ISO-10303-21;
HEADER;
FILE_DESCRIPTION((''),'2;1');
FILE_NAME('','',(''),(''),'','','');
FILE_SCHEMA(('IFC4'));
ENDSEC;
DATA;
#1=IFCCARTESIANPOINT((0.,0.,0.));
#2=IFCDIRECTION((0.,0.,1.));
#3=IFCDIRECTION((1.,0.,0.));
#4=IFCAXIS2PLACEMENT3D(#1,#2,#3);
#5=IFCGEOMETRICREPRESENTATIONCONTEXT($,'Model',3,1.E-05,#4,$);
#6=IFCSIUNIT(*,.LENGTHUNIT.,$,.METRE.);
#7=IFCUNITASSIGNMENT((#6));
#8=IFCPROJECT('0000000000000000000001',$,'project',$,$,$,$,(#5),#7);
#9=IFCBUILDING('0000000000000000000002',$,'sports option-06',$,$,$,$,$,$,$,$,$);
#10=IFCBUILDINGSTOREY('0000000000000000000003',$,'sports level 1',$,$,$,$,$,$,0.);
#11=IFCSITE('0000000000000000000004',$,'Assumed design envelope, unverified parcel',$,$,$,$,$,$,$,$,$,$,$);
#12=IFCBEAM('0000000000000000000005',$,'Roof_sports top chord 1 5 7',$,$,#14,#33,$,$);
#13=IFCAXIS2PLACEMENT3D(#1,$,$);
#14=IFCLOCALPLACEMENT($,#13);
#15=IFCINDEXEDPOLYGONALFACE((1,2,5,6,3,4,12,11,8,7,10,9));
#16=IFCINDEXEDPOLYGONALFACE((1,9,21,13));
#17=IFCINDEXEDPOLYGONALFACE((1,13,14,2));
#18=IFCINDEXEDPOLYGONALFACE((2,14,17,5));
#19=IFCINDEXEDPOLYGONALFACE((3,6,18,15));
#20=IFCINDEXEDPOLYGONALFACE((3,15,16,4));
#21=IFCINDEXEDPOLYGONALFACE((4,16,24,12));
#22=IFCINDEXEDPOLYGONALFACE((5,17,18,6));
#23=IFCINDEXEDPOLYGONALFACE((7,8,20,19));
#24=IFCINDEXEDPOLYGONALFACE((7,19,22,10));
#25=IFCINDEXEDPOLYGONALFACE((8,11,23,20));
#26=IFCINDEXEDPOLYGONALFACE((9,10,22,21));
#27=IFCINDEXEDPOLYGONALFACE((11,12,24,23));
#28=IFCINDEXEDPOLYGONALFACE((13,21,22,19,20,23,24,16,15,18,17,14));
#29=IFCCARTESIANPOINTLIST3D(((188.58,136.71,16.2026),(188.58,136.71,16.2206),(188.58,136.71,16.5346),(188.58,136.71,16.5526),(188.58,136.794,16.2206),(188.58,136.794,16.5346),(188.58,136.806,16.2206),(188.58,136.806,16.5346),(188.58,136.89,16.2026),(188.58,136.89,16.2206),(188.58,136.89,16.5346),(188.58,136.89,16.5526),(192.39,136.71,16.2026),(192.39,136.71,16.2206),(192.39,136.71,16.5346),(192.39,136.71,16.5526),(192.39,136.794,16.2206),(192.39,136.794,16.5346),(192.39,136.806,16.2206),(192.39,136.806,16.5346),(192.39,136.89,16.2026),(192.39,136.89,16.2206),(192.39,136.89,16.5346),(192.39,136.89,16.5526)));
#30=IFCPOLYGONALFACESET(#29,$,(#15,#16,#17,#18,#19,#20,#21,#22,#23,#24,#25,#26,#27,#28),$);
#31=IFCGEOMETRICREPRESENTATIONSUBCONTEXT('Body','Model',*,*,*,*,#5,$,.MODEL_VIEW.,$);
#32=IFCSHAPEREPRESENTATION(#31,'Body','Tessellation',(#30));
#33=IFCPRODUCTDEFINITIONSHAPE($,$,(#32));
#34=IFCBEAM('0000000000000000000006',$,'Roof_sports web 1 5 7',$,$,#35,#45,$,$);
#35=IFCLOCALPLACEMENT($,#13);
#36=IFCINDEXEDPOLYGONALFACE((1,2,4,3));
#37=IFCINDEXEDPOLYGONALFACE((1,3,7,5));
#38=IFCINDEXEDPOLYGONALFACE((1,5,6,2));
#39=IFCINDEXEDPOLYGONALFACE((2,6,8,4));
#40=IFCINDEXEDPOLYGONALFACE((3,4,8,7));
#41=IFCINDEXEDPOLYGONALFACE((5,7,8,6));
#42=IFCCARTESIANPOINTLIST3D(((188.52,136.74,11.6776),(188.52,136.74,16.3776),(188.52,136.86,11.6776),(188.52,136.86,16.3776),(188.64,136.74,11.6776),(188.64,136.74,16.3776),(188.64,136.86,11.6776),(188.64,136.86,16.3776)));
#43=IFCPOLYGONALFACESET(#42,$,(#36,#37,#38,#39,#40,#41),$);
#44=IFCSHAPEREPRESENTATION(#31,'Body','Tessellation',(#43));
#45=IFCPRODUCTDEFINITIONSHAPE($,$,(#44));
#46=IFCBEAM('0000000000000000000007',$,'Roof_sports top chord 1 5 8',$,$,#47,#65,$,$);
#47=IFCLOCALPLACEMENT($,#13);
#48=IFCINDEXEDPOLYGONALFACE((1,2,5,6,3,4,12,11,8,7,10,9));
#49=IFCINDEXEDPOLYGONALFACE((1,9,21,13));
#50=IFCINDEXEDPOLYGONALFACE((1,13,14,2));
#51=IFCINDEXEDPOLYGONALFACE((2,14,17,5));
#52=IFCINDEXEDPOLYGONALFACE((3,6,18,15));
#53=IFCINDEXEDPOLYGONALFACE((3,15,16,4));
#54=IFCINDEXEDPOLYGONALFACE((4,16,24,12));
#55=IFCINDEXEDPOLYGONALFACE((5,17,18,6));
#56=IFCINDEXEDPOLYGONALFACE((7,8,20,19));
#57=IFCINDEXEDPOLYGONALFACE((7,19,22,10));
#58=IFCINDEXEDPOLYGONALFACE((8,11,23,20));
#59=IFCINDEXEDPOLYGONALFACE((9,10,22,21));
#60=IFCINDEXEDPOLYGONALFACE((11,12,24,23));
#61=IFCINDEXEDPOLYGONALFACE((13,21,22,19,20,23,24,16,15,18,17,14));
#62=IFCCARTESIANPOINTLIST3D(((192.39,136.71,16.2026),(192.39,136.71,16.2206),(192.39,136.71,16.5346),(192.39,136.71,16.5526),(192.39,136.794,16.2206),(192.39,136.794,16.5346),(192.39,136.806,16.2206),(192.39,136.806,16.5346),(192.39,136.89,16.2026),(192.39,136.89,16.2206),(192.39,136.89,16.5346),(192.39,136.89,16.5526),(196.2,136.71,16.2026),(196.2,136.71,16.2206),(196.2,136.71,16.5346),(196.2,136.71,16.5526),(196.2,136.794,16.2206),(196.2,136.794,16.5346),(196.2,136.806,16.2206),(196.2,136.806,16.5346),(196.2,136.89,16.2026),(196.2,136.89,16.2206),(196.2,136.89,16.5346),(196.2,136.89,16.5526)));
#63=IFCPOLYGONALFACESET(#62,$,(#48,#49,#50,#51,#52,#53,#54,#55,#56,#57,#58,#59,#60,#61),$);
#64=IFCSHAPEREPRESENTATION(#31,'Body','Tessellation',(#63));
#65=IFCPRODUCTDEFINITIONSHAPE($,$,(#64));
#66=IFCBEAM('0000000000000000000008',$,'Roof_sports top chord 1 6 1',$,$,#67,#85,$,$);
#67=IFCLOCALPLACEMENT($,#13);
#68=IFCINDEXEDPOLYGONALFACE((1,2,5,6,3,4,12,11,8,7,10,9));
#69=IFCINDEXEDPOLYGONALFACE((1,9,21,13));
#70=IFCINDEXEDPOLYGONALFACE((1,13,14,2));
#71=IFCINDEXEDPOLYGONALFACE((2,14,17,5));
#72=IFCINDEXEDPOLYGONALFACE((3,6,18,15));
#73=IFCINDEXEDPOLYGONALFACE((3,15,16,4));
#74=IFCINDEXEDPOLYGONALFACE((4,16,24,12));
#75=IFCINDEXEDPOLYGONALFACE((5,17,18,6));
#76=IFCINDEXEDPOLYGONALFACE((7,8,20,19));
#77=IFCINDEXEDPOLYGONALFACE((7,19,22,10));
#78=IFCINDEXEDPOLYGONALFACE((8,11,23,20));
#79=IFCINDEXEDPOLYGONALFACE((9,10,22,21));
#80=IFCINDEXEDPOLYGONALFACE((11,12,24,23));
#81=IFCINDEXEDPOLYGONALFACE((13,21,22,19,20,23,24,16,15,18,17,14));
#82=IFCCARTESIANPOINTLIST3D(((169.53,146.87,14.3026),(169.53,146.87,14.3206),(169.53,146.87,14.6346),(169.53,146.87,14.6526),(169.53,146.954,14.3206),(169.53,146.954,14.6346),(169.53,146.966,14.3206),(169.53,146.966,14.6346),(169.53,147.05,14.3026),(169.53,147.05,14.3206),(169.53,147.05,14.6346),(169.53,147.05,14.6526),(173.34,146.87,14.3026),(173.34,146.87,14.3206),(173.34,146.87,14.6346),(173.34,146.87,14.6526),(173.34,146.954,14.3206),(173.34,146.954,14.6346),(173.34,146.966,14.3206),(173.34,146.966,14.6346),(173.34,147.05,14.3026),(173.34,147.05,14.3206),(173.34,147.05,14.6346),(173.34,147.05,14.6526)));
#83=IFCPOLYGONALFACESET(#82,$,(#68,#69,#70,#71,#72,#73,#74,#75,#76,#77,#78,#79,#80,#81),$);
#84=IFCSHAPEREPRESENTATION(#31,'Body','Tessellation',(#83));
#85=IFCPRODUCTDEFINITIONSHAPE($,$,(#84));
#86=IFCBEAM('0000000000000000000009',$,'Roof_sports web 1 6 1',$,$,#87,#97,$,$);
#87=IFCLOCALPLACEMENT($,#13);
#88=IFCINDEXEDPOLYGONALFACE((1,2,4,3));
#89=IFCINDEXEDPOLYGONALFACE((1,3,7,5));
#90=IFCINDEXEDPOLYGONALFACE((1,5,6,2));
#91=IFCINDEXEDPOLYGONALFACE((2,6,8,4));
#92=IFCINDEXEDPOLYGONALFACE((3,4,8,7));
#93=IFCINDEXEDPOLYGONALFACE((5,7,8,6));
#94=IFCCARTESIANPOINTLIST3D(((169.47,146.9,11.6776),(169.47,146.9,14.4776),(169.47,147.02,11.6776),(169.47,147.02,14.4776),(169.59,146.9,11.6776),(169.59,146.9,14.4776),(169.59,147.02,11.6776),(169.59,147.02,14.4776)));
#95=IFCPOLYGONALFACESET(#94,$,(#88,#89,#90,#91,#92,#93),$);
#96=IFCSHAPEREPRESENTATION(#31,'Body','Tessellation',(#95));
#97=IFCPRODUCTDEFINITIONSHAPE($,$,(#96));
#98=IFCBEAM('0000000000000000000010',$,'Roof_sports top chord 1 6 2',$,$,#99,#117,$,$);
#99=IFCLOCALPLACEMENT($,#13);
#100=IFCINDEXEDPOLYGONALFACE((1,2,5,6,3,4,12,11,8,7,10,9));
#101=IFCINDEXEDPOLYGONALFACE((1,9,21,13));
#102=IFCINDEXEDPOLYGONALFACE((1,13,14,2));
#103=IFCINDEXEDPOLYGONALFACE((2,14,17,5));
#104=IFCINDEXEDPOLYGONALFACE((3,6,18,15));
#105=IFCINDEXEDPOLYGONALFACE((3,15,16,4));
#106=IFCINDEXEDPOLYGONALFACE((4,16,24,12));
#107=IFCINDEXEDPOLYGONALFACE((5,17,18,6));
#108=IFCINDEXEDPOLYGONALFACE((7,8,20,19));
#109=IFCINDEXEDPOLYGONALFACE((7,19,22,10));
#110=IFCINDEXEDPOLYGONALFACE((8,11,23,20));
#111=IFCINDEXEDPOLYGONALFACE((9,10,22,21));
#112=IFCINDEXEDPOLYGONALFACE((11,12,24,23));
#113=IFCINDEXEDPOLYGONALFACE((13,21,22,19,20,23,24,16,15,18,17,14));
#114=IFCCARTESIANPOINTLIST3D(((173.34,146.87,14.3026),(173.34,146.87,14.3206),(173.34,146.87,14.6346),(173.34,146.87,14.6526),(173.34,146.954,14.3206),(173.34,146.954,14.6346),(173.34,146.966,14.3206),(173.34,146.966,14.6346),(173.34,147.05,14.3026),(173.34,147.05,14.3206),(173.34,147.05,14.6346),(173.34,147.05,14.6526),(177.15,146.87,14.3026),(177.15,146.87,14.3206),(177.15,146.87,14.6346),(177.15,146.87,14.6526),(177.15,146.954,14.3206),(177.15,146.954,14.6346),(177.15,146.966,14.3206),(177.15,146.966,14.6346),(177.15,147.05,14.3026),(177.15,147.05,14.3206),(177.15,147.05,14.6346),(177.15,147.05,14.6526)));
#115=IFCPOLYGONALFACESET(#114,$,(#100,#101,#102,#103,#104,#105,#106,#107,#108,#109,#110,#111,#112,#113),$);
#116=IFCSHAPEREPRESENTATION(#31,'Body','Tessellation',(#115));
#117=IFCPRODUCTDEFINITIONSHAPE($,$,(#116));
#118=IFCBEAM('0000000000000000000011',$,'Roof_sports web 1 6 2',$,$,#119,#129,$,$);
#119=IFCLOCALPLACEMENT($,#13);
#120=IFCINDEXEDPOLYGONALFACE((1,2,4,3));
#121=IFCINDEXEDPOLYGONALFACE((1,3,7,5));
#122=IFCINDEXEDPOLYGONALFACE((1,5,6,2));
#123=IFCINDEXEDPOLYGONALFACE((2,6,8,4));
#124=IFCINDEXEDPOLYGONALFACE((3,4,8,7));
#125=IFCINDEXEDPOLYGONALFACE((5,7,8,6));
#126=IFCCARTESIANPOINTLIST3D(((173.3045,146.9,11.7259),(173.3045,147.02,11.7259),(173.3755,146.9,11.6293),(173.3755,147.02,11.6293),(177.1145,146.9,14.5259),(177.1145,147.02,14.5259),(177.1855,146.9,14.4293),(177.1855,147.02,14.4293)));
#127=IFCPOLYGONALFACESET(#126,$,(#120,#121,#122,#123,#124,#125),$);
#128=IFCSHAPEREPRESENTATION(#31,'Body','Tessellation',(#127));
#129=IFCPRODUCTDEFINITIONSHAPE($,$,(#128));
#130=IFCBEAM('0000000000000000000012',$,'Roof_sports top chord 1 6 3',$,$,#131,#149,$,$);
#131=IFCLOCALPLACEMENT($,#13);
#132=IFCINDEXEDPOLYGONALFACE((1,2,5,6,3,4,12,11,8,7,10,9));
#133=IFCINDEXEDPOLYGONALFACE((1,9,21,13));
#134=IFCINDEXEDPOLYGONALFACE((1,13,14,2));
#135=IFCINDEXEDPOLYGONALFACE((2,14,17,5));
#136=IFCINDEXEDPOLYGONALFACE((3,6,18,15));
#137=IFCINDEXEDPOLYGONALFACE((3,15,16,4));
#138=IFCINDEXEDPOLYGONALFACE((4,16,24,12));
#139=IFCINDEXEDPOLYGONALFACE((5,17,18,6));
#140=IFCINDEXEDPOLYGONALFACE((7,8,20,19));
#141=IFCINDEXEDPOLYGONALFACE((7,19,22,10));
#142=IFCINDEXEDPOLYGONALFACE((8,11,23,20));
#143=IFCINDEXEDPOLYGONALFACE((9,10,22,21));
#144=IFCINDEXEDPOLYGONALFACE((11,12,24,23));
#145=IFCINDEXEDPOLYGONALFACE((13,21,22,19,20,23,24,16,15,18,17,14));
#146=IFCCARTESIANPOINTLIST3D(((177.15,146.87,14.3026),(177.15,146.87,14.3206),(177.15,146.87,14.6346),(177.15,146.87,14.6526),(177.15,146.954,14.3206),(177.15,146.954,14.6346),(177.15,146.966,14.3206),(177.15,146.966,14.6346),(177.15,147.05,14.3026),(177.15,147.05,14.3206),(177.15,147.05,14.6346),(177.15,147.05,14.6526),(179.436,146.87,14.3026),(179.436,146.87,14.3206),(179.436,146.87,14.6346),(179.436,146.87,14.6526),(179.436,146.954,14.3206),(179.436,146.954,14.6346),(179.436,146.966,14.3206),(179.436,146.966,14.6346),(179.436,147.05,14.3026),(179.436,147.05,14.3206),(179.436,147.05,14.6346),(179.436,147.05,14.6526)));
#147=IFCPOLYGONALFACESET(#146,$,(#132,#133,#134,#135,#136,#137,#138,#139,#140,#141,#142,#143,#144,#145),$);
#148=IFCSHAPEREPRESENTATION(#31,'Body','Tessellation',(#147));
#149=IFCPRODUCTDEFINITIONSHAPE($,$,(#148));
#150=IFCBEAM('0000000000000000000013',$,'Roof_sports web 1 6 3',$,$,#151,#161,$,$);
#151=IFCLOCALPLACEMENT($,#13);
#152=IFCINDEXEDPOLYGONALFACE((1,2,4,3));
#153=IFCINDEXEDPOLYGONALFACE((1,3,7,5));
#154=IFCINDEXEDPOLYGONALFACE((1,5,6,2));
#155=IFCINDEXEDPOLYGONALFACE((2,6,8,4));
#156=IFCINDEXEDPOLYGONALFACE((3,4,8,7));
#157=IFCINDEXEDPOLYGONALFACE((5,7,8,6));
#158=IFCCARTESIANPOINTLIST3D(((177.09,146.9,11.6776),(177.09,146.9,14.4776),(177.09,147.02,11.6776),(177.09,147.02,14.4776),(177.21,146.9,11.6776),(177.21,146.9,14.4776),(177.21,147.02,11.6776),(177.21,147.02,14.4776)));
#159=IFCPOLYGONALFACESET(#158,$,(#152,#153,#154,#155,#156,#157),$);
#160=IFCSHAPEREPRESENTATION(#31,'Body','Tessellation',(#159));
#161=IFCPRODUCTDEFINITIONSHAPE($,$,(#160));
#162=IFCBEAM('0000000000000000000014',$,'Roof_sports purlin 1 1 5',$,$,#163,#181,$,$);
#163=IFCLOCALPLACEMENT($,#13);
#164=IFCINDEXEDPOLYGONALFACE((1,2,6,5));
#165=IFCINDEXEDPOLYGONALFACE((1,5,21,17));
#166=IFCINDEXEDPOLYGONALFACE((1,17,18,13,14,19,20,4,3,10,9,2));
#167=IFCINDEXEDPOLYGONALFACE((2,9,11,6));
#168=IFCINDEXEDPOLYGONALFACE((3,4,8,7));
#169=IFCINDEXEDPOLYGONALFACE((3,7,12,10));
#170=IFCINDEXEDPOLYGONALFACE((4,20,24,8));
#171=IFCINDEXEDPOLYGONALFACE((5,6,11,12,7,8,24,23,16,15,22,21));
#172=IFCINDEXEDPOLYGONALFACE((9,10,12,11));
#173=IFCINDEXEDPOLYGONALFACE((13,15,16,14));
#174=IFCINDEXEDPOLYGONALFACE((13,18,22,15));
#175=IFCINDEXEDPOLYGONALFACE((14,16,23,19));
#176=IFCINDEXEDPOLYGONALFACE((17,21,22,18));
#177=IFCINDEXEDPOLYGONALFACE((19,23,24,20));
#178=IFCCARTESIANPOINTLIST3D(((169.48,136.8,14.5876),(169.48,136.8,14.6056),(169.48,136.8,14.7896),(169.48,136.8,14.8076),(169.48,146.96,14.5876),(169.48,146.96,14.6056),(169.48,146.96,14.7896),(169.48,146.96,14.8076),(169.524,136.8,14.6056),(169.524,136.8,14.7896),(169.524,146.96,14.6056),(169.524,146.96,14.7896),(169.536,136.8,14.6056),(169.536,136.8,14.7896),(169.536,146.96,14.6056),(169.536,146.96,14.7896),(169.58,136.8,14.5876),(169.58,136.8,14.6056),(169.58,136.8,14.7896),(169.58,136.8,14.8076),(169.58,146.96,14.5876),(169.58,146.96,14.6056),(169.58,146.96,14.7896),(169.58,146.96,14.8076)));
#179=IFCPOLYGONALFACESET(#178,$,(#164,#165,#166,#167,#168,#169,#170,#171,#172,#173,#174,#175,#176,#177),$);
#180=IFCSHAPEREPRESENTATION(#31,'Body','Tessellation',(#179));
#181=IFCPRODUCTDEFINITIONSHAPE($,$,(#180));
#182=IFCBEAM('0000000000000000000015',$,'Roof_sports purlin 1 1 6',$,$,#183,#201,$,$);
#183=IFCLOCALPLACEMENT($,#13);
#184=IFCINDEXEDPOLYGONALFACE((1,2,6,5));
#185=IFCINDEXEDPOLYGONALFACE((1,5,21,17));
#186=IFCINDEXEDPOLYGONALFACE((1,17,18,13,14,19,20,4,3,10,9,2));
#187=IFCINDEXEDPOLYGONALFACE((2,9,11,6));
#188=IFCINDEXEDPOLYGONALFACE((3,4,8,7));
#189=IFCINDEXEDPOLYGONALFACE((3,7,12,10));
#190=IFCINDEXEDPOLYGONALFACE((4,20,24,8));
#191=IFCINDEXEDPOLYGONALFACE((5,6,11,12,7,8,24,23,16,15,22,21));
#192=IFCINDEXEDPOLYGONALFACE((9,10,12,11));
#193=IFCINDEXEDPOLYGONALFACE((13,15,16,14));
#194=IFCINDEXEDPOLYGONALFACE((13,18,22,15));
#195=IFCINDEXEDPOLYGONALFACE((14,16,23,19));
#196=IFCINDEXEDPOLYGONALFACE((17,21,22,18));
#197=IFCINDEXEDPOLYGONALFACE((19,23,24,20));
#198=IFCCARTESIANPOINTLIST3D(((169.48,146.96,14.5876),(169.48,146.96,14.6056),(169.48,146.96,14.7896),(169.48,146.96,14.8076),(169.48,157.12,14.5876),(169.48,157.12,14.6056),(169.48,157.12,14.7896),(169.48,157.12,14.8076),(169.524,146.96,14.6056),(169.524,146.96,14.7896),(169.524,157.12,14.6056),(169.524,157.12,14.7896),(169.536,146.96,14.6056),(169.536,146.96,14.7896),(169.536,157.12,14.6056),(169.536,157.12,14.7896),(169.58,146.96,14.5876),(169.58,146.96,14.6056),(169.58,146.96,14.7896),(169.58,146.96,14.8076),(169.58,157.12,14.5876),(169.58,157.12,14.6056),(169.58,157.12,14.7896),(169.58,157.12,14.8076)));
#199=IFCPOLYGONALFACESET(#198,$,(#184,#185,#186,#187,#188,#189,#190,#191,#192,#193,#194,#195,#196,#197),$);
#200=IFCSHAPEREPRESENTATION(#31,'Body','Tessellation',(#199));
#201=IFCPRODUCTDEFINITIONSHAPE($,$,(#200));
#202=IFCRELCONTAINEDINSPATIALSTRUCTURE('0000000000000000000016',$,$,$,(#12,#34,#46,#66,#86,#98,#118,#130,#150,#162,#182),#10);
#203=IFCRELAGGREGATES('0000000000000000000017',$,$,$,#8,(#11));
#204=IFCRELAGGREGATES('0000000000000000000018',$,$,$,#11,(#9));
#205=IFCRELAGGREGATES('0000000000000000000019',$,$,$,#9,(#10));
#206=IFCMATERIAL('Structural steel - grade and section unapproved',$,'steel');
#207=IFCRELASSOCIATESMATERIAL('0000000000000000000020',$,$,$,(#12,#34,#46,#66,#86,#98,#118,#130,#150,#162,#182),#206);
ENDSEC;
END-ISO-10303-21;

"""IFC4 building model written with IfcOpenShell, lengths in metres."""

from ifc_helpers import new_model, si_unit, frame, origin_with_axes, place, context, subcontext, project, spatial, rectangle, i_section, extrude, material, element, save


model = new_model("IFC4")

# Units and contexts
model_context = context("Model", 3, precision=1e-05, world=origin_with_axes())
body_context = subcontext(model_context, "Body", "Model", "MODEL_VIEW")
ifc_project = project(units=[si_unit("LENGTHUNIT", "METRE")], contexts=[model_context])

# Site, building, storey
site = spatial("IfcSite", under=ifc_project, Name="Assumed design envelope, unverified parcel")
building = spatial("IfcBuilding", under=site, Name="sports option-06")
storey = spatial("IfcBuildingStorey", under=building, Name="sports level 1", Elevation=0.0)

# Beams
ifc_material_1 = material(Name="Structural steel - grade and section unapproved", Category="steel")
beam_1_placement = place(None, frame((188.58, 136.8, 16.3776), z_axis=(1.0, 0.0, 0.0), x_axis=(0.0, 1.0, 0.0)))
element("IfcBeam", 1, at=beam_1_placement, inside=storey, material=ifc_material_1, Name="Roof_sports top chord 1 5 7", context=body_context, shape_type="SweptSolid", body=[
    extrude(i_section(OverallWidth=0.18, OverallDepth=0.35, WebThickness=0.012, FlangeThickness=0.018, FilletRadius=0.0), origin_with_axes(), (0.0, 0.0, 1.0), 3.81),
])
beam_2_placement = place(None, frame((188.58, 136.8, 11.6776), z_axis=(0.0, 0.0, 1.0), x_axis=(-1.0, 0.0, 0.0)))
element("IfcBeam", 2, at=beam_2_placement, inside=storey, material=ifc_material_1, Name="Roof_sports web 1 5 7", context=body_context, shape_type="SweptSolid", body=[
    extrude(rectangle(XDim=0.12, YDim=0.12), origin_with_axes(), (0.0, 0.0, 1.0), 4.7),
])
for number, where, z_axis, x_axis, name in (
    (3, (192.39, 136.8, 16.3776), (1.0, 0.0, 0.0), (0.0, 1.0, 0.0), "Roof_sports top chord 1 5 8"),
    (4, (169.53, 146.96, 14.4776), (1.0, 0.0, 0.0), (0.0, 1.0, 0.0), "Roof_sports top chord 1 6 1"),
):
    element("IfcBeam", number, at=place(None, frame(where, z_axis=z_axis, x_axis=x_axis)), inside=storey, material=ifc_material_1, Name=name, context=body_context, shape_type="SweptSolid", body=[
        extrude(i_section(OverallWidth=0.18, OverallDepth=0.35, WebThickness=0.012, FlangeThickness=0.018, FilletRadius=0.0), origin_with_axes(), (0.0, 0.0, 1.0), 3.81),
    ])
beam_3_placement = place(None, frame((169.53, 146.96, 11.6776), z_axis=(0.0, 0.0, 1.0), x_axis=(-1.0, 0.0, 0.0)))
element("IfcBeam", 5, at=beam_3_placement, inside=storey, material=ifc_material_1, Name="Roof_sports web 1 6 1", context=body_context, shape_type="SweptSolid", body=[
    extrude(rectangle(XDim=0.12, YDim=0.12), origin_with_axes(), (0.0, 0.0, 1.0), 2.8),
])
beam_4_placement = place(None, frame((173.34, 146.96, 14.4776), z_axis=(1.0, 0.0, 0.0), x_axis=(0.0, 1.0, 0.0)))
element("IfcBeam", 6, at=beam_4_placement, inside=storey, material=ifc_material_1, Name="Roof_sports top chord 1 6 2", context=body_context, shape_type="SweptSolid", body=[
    extrude(i_section(OverallWidth=0.18, OverallDepth=0.35, WebThickness=0.012, FlangeThickness=0.018, FilletRadius=0.0), origin_with_axes(), (0.0, 0.0, 1.0), 3.81),
])
beam_5_placement = place(None, frame((173.34, 146.96, 11.6776), z_axis=(0.805799, 0.0, 0.592189), x_axis=(0.0, 1.0, 0.0)))
element("IfcBeam", 7, at=beam_5_placement, inside=storey, material=ifc_material_1, Name="Roof_sports web 1 6 2", context=body_context, shape_type="SweptSolid", body=[
    extrude(rectangle(XDim=0.12, YDim=0.12), origin_with_axes(), (0.0, 0.0, 1.0), 4.7282),
])
beam_6_placement = place(None, frame((177.15, 146.96, 14.4776), z_axis=(1.0, 0.0, 0.0), x_axis=(0.0, 1.0, 0.0)))
element("IfcBeam", 8, at=beam_6_placement, inside=storey, material=ifc_material_1, Name="Roof_sports top chord 1 6 3", context=body_context, shape_type="SweptSolid", body=[
    extrude(i_section(OverallWidth=0.18, OverallDepth=0.35, WebThickness=0.012, FlangeThickness=0.018, FilletRadius=0.0), origin_with_axes(), (0.0, 0.0, 1.0), 2.286),
])
beam_7_placement = place(None, frame((177.15, 146.96, 11.6776), z_axis=(0.0, 0.0, 1.0), x_axis=(-1.0, 0.0, 0.0)))
element("IfcBeam", 9, at=beam_7_placement, inside=storey, material=ifc_material_1, Name="Roof_sports web 1 6 3", context=body_context, shape_type="SweptSolid", body=[
    extrude(rectangle(XDim=0.12, YDim=0.12), origin_with_axes(), (0.0, 0.0, 1.0), 2.8),
])
beam_8_placement = place(None, frame((169.53, 136.8, 14.6976), z_axis=(0.0, 1.0, 0.0), x_axis=(-1.0, 0.0, 0.0)))
element("IfcBeam", 10, at=beam_8_placement, inside=storey, material=ifc_material_1, Name="Roof_sports purlin 1 1 5", context=body_context, shape_type="SweptSolid", body=[
    extrude(i_section(OverallWidth=0.1, OverallDepth=0.22, WebThickness=0.012, FlangeThickness=0.018, FilletRadius=0.0), origin_with_axes(), (0.0, 0.0, 1.0), 10.16),
])
beam_9_placement = place(None, frame((169.53, 146.96, 14.6976), z_axis=(0.0, 1.0, 0.0), x_axis=(-1.0, 0.0, 0.0)))
element("IfcBeam", 11, at=beam_9_placement, inside=storey, material=ifc_material_1, Name="Roof_sports purlin 1 1 6", context=body_context, shape_type="SweptSolid", body=[
    extrude(i_section(OverallWidth=0.1, OverallDepth=0.22, WebThickness=0.012, FlangeThickness=0.018, FilletRadius=0.0), origin_with_axes(), (0.0, 0.0, 1.0), 10.16),
])

save(model, "model.ifc")
